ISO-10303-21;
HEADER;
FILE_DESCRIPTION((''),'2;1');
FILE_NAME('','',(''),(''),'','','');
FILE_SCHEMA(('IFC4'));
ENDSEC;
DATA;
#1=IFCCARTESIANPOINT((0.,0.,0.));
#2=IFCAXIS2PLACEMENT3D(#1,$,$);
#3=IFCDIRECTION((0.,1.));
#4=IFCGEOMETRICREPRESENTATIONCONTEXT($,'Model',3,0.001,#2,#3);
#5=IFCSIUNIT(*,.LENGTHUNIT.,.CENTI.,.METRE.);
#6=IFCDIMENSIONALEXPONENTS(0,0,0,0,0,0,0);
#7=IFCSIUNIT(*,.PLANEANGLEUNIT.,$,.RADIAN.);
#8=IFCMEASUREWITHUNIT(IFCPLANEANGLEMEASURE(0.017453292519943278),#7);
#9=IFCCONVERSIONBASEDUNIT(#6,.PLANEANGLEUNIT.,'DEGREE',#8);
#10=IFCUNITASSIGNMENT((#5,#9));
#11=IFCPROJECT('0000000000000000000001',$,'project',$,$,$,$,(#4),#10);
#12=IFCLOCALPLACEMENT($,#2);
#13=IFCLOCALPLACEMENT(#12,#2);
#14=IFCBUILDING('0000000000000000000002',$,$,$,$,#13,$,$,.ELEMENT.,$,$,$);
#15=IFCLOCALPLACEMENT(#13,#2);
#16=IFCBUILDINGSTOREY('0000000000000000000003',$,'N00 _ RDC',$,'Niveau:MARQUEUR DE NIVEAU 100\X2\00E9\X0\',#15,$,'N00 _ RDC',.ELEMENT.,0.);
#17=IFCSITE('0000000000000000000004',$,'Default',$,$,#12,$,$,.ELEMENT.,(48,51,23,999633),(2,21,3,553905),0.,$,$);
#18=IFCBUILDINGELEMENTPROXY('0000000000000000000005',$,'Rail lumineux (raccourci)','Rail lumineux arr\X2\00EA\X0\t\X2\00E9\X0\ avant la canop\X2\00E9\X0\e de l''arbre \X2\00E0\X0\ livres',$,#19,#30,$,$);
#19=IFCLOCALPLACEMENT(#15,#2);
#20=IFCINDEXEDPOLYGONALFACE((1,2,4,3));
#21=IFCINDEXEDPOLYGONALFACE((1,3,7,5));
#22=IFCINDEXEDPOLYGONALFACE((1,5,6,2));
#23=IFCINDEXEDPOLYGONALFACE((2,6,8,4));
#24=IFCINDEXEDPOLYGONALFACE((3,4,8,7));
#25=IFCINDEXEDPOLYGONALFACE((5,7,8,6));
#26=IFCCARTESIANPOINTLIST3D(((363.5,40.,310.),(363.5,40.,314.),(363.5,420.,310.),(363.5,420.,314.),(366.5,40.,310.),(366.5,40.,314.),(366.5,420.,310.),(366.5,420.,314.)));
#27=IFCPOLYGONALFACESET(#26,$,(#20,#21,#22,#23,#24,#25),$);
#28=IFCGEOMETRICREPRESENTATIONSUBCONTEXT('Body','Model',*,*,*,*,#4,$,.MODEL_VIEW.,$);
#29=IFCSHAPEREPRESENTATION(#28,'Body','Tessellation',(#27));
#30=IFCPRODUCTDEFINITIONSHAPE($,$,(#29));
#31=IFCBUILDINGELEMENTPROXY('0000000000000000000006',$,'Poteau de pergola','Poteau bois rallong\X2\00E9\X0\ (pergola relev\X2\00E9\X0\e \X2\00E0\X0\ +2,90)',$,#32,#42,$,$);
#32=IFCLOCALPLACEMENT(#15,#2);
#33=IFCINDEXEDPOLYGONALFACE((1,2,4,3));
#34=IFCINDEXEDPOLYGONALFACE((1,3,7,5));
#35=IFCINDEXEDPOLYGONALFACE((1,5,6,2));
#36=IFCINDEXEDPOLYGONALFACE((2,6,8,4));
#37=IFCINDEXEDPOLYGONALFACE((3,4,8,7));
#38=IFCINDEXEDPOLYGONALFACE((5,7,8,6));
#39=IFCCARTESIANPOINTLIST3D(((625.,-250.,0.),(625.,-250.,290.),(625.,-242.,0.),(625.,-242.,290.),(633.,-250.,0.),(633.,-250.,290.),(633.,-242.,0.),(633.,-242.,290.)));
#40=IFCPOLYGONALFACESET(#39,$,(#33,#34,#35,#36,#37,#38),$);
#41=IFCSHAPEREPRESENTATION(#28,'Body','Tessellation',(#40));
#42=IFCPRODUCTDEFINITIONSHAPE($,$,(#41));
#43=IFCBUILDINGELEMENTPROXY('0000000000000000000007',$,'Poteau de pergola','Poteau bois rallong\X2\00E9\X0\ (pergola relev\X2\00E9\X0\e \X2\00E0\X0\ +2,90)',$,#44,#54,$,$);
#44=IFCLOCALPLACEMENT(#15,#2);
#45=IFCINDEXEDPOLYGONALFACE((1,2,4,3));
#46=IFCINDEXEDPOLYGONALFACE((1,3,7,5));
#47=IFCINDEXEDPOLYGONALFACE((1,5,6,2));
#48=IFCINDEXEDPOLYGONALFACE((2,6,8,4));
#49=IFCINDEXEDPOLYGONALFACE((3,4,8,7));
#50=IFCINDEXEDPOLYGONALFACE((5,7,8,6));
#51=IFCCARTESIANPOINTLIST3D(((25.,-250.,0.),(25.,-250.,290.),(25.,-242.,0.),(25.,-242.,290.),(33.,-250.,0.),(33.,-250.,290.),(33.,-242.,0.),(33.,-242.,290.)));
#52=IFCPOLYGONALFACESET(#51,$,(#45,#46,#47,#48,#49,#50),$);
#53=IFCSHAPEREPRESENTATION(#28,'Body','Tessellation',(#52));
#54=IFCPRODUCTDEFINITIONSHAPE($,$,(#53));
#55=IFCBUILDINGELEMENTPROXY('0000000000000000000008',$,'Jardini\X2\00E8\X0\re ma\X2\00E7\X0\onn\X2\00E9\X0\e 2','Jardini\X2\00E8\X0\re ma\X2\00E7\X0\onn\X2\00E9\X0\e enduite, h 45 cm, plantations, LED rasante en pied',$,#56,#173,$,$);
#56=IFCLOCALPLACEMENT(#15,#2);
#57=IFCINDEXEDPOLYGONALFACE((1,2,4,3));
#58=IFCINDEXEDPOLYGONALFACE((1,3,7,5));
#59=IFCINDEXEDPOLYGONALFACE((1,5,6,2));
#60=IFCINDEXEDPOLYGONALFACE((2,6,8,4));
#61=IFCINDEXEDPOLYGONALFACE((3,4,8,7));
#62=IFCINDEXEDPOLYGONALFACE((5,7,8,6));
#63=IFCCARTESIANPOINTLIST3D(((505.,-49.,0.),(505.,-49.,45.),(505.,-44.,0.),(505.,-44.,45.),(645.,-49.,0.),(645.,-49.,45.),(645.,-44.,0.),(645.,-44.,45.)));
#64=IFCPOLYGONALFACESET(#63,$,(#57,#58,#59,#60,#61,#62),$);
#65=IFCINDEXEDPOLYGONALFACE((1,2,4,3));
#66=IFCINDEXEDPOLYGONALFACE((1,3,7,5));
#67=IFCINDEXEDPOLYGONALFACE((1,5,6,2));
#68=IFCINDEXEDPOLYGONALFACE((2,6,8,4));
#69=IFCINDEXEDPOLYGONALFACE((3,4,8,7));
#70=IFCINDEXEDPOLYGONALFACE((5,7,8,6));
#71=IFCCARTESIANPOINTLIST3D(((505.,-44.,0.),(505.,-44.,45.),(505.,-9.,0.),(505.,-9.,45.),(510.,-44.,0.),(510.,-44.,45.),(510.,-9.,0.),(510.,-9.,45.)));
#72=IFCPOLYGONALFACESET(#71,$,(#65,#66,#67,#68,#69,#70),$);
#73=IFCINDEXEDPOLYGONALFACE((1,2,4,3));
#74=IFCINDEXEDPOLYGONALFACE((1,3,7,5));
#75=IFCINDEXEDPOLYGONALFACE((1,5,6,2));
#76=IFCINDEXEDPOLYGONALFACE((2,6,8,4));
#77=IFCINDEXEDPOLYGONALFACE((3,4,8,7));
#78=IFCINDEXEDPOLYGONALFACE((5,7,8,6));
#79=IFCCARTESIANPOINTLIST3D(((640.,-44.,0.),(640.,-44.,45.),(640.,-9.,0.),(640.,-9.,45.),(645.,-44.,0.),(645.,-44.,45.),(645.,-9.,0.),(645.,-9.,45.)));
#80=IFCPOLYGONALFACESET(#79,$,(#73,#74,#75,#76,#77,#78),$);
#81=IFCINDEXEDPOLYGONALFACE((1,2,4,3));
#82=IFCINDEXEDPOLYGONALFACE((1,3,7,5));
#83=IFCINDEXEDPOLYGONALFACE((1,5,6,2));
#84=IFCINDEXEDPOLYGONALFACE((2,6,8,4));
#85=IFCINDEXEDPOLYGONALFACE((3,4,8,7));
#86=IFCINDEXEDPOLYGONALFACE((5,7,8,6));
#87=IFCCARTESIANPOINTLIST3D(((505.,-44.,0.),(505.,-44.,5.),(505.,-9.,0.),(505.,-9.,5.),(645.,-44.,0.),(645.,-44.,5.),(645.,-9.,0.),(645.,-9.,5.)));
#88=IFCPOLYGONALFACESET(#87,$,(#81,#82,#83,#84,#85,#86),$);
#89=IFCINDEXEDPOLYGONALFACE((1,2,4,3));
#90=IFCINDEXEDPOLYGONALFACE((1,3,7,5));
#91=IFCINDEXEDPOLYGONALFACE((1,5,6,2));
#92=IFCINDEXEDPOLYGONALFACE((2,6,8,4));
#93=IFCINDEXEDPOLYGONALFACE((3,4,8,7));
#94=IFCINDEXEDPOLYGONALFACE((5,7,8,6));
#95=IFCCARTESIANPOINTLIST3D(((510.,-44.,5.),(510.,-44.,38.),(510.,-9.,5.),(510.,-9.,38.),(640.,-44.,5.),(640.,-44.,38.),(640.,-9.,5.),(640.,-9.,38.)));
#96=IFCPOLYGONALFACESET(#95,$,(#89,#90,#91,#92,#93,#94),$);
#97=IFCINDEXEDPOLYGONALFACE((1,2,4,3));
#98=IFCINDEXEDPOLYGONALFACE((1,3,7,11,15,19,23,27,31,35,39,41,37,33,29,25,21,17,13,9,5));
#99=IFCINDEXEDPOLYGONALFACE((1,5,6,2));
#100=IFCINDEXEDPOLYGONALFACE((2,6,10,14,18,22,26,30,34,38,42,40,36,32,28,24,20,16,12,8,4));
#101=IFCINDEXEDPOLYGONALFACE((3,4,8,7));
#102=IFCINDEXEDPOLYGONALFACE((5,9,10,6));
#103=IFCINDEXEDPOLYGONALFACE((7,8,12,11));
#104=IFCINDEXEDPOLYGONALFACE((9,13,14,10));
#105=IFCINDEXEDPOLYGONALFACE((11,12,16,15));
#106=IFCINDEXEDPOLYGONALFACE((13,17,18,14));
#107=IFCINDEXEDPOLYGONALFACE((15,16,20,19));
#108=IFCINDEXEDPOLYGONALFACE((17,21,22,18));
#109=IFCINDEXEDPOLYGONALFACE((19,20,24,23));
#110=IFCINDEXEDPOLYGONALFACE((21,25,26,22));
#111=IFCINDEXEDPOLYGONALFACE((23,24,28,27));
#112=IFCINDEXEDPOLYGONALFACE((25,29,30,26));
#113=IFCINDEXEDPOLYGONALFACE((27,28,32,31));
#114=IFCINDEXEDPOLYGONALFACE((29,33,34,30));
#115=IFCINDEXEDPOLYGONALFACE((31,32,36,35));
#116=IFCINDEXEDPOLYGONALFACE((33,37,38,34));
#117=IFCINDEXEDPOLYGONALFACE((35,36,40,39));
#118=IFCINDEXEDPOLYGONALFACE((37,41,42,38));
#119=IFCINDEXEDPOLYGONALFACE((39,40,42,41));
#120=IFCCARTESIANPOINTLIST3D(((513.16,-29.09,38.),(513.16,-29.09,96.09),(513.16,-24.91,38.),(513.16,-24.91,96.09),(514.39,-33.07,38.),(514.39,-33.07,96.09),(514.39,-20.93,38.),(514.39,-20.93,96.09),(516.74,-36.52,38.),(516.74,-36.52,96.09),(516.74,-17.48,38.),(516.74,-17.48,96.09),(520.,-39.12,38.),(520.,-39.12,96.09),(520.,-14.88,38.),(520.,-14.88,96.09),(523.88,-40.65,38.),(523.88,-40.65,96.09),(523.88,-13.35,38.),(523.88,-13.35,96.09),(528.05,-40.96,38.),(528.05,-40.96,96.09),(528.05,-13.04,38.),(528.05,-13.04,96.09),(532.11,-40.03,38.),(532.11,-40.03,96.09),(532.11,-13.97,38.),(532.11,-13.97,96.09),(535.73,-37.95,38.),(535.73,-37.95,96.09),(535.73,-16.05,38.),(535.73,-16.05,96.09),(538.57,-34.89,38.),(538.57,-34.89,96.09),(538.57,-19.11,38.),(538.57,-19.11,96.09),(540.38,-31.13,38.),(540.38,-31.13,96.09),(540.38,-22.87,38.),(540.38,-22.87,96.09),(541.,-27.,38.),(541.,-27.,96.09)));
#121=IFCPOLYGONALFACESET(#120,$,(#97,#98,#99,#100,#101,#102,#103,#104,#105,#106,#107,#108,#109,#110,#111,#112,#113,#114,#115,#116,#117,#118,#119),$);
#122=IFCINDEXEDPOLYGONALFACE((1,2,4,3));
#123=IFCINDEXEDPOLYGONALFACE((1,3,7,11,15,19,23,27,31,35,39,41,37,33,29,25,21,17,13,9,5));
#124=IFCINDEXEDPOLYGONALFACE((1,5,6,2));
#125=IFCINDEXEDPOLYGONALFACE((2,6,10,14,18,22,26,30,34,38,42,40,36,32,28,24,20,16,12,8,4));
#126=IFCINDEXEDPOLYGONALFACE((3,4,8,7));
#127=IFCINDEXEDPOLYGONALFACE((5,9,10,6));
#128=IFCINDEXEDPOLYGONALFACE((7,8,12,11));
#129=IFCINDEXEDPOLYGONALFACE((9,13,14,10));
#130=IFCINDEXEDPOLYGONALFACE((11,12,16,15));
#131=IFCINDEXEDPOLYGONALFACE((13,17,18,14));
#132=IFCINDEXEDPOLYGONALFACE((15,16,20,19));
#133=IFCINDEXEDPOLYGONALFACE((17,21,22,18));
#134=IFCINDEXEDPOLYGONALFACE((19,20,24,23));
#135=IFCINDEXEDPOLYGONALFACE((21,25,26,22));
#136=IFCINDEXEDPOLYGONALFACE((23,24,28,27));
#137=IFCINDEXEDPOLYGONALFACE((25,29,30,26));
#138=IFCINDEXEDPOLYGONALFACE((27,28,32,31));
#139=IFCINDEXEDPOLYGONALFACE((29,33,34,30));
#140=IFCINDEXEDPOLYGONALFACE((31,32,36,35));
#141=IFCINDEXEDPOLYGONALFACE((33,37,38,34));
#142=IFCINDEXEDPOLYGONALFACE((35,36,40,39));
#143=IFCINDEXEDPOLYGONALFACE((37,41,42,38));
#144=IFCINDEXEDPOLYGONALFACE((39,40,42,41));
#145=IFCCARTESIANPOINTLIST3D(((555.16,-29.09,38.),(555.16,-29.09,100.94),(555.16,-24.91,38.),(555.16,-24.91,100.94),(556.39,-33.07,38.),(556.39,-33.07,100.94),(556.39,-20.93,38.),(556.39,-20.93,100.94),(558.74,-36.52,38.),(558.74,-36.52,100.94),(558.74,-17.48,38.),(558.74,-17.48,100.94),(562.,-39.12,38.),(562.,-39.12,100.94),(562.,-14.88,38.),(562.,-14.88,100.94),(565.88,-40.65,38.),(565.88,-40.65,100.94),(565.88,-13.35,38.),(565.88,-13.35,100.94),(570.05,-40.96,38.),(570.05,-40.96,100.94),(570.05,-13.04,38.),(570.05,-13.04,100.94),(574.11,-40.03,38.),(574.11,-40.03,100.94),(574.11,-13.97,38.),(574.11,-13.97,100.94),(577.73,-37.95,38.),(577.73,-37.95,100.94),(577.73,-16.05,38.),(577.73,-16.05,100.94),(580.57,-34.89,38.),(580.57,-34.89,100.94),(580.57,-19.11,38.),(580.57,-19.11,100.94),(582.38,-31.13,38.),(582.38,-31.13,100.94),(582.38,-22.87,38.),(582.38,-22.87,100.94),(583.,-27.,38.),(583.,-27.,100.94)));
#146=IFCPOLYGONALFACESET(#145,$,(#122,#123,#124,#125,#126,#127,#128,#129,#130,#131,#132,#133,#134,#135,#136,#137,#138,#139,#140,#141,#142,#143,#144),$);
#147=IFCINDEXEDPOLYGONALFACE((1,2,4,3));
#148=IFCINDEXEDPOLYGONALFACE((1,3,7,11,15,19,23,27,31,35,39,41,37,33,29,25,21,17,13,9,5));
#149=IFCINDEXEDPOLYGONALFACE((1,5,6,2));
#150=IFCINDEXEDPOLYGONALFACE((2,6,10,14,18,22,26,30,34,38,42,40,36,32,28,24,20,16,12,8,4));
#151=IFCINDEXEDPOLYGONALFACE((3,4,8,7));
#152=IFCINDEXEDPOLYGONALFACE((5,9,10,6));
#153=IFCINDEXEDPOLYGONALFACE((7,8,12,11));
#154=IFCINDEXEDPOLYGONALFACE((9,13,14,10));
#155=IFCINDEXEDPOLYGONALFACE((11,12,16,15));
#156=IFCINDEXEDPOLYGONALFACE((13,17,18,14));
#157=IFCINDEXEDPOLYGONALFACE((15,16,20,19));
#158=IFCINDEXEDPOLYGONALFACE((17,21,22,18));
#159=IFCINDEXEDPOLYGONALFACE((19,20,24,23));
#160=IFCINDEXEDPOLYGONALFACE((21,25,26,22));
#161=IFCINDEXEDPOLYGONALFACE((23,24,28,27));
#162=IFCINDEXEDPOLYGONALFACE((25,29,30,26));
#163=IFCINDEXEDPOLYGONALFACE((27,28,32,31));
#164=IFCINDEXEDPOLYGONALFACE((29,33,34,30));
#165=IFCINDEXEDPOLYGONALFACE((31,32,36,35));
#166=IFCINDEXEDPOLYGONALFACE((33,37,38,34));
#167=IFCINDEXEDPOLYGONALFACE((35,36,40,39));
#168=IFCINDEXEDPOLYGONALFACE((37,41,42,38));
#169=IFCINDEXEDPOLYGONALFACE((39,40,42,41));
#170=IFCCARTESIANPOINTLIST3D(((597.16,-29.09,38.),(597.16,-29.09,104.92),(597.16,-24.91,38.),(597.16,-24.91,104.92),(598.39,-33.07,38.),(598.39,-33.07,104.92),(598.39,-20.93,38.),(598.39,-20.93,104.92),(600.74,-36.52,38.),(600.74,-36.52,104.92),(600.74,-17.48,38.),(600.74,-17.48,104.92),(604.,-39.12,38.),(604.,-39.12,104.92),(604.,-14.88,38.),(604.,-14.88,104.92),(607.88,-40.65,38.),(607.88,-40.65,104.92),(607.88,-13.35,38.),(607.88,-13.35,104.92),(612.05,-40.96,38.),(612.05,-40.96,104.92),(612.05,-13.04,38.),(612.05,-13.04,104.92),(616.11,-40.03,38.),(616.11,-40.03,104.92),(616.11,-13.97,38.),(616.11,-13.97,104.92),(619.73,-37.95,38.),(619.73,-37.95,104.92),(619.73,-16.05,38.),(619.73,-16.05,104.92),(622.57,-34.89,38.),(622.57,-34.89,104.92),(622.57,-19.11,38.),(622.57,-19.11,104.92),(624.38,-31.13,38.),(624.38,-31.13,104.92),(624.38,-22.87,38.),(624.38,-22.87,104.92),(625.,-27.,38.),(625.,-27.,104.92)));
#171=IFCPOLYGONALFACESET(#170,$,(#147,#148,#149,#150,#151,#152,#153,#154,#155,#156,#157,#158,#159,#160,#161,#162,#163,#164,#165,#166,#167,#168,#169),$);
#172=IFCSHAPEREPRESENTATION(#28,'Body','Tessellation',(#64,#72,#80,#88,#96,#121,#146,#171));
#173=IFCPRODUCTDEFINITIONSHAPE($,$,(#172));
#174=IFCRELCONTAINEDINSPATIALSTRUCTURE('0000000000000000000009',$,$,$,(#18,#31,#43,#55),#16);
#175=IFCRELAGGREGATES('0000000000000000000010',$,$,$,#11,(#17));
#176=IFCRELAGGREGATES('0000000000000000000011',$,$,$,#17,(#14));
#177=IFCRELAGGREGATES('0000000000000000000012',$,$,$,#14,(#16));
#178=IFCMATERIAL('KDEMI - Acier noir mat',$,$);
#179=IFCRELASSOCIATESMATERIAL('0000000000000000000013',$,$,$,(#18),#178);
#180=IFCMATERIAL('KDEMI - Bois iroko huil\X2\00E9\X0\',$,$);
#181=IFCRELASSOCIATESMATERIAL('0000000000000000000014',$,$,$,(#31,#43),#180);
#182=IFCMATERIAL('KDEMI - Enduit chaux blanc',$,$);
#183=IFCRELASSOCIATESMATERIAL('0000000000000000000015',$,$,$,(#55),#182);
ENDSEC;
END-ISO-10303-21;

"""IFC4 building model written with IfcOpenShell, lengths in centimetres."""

from ifc_helpers import new_model, entity, si_unit, converted_unit, direction, frame, frame_2d, origin, origin_with_axes, place, context, subcontext, project, spatial, rectangle, circle, extrude, material, element, save


model = new_model("IFC4")

# Units and contexts
model_context = context("Model", 3, precision=0.001, world=origin(), true_north=direction((0.0, 1.0)))
body_context = subcontext(model_context, "Body", "Model", "MODEL_VIEW")
ifc_project = project(units=[si_unit("LENGTHUNIT", "METRE", prefix="CENTI"), converted_unit("PLANEANGLEUNIT", "DEGREE", entity("IfcPlaneAngleMeasure", 0.017453292519943278), si_unit("PLANEANGLEUNIT", "RADIAN"), dimensions=[0, 0, 0, 0, 0, 0, 0])], contexts=[model_context])

# Site, building, storey
site_placement = place(None, origin())
site = spatial("IfcSite", under=ifc_project, at=site_placement, Name="Default", CompositionType="ELEMENT", RefLatitude=(48, 51, 23, 999633), RefLongitude=(2, 21, 3, 553905), RefElevation=0.0)
building_placement = place(site_placement, origin())
building = spatial("IfcBuilding", under=site, at=building_placement, CompositionType="ELEMENT")
storey_placement = place(building_placement, origin())
storey = spatial("IfcBuildingStorey", under=building, at=storey_placement, Name="N00 _ RDC", ObjectType="Niveau:MARQUEUR DE NIVEAU 100é", LongName="N00 _ RDC", CompositionType="ELEMENT", Elevation=0.0)

# Shared definitions
ifc_material_1 = material(Name="KDEMI - Bois iroko huilé")

# Building element proxies
ifc_material_2 = material(Name="KDEMI - Acier noir mat")
proxy_1_placement = place(storey_placement, origin_with_axes())
element("IfcBuildingElementProxy", 1, at=proxy_1_placement, inside=storey, material=ifc_material_2, Name="Rail lumineux (raccourci)", Description="Rail lumineux arrêté avant la canopée de l'arbre à livres", context=body_context, shape_type="SweptSolid", body=[
    extrude(rectangle(XDim=3.0, YDim=380.0, at=frame_2d((365.0, 230.0))), frame((0.0, 0.0, 310.0)), (0.0, 0.0, 1.0), 4.0),
])
proxy_2_placement = place(storey_placement, origin_with_axes())
element("IfcBuildingElementProxy", 2, at=proxy_2_placement, inside=storey, material=ifc_material_1, Name="Poteau de pergola", Description="Poteau bois rallongé (pergola relevée à +2,90)", context=body_context, shape_type="SweptSolid", body=[
    extrude(rectangle(XDim=8.0, YDim=8.0, at=frame_2d((629.0, -246.0))), origin(), (0.0, 0.0, 1.0), 290.0),
])
proxy_3_placement = place(storey_placement, origin_with_axes())
element("IfcBuildingElementProxy", 3, at=proxy_3_placement, inside=storey, material=ifc_material_1, Name="Poteau de pergola", Description="Poteau bois rallongé (pergola relevée à +2,90)", context=body_context, shape_type="SweptSolid", body=[
    extrude(rectangle(XDim=8.0, YDim=8.0, at=frame_2d((29.0, -246.0))), origin(), (0.0, 0.0, 1.0), 290.0),
])
ifc_material_3 = material(Name="KDEMI - Enduit chaux blanc")
proxy_4_placement = place(storey_placement, origin_with_axes())
element("IfcBuildingElementProxy", 4, at=proxy_4_placement, inside=storey, material=ifc_material_3, Name="Jardinière maçonnée 2", Description="Jardinière maçonnée enduite, h 45 cm, plantations, LED rasante en pied", context=body_context, shape_type="SweptSolid", body=[
    extrude(rectangle(XDim=140.0, YDim=5.0, at=frame_2d((575.0, -46.5))), origin(), (0.0, 0.0, 1.0), 45.0),
    extrude(rectangle(XDim=5.0, YDim=35.0, at=frame_2d((507.5, -26.5))), origin(), (0.0, 0.0, 1.0), 45.0),
    extrude(rectangle(XDim=5.0, YDim=35.0, at=frame_2d((642.5, -26.5))), origin(), (0.0, 0.0, 1.0), 45.0),
    extrude(rectangle(XDim=140.0, YDim=35.0, at=frame_2d((575.0, -26.5))), origin(), (0.0, 0.0, 1.0), 5.0),
    extrude(rectangle(XDim=130.0, YDim=35.0, at=frame_2d((575.0, -26.5))), frame((0.0, 0.0, 5.0)), (0.0, 0.0, 1.0), 33.0),
    extrude(circle(Radius=14.0, at=frame_2d((527.0, -27.0))), frame((0.0, 0.0, 38.0)), (0.0, 0.0, 1.0), 58.09),
    extrude(circle(Radius=14.0, at=frame_2d((569.0, -27.0))), frame((0.0, 0.0, 38.0)), (0.0, 0.0, 1.0), 62.94),
    extrude(circle(Radius=14.0, at=frame_2d((611.0, -27.0))), frame((0.0, 0.0, 38.0)), (0.0, 0.0, 1.0), 66.92),
])

save(model, "model.ifc")
